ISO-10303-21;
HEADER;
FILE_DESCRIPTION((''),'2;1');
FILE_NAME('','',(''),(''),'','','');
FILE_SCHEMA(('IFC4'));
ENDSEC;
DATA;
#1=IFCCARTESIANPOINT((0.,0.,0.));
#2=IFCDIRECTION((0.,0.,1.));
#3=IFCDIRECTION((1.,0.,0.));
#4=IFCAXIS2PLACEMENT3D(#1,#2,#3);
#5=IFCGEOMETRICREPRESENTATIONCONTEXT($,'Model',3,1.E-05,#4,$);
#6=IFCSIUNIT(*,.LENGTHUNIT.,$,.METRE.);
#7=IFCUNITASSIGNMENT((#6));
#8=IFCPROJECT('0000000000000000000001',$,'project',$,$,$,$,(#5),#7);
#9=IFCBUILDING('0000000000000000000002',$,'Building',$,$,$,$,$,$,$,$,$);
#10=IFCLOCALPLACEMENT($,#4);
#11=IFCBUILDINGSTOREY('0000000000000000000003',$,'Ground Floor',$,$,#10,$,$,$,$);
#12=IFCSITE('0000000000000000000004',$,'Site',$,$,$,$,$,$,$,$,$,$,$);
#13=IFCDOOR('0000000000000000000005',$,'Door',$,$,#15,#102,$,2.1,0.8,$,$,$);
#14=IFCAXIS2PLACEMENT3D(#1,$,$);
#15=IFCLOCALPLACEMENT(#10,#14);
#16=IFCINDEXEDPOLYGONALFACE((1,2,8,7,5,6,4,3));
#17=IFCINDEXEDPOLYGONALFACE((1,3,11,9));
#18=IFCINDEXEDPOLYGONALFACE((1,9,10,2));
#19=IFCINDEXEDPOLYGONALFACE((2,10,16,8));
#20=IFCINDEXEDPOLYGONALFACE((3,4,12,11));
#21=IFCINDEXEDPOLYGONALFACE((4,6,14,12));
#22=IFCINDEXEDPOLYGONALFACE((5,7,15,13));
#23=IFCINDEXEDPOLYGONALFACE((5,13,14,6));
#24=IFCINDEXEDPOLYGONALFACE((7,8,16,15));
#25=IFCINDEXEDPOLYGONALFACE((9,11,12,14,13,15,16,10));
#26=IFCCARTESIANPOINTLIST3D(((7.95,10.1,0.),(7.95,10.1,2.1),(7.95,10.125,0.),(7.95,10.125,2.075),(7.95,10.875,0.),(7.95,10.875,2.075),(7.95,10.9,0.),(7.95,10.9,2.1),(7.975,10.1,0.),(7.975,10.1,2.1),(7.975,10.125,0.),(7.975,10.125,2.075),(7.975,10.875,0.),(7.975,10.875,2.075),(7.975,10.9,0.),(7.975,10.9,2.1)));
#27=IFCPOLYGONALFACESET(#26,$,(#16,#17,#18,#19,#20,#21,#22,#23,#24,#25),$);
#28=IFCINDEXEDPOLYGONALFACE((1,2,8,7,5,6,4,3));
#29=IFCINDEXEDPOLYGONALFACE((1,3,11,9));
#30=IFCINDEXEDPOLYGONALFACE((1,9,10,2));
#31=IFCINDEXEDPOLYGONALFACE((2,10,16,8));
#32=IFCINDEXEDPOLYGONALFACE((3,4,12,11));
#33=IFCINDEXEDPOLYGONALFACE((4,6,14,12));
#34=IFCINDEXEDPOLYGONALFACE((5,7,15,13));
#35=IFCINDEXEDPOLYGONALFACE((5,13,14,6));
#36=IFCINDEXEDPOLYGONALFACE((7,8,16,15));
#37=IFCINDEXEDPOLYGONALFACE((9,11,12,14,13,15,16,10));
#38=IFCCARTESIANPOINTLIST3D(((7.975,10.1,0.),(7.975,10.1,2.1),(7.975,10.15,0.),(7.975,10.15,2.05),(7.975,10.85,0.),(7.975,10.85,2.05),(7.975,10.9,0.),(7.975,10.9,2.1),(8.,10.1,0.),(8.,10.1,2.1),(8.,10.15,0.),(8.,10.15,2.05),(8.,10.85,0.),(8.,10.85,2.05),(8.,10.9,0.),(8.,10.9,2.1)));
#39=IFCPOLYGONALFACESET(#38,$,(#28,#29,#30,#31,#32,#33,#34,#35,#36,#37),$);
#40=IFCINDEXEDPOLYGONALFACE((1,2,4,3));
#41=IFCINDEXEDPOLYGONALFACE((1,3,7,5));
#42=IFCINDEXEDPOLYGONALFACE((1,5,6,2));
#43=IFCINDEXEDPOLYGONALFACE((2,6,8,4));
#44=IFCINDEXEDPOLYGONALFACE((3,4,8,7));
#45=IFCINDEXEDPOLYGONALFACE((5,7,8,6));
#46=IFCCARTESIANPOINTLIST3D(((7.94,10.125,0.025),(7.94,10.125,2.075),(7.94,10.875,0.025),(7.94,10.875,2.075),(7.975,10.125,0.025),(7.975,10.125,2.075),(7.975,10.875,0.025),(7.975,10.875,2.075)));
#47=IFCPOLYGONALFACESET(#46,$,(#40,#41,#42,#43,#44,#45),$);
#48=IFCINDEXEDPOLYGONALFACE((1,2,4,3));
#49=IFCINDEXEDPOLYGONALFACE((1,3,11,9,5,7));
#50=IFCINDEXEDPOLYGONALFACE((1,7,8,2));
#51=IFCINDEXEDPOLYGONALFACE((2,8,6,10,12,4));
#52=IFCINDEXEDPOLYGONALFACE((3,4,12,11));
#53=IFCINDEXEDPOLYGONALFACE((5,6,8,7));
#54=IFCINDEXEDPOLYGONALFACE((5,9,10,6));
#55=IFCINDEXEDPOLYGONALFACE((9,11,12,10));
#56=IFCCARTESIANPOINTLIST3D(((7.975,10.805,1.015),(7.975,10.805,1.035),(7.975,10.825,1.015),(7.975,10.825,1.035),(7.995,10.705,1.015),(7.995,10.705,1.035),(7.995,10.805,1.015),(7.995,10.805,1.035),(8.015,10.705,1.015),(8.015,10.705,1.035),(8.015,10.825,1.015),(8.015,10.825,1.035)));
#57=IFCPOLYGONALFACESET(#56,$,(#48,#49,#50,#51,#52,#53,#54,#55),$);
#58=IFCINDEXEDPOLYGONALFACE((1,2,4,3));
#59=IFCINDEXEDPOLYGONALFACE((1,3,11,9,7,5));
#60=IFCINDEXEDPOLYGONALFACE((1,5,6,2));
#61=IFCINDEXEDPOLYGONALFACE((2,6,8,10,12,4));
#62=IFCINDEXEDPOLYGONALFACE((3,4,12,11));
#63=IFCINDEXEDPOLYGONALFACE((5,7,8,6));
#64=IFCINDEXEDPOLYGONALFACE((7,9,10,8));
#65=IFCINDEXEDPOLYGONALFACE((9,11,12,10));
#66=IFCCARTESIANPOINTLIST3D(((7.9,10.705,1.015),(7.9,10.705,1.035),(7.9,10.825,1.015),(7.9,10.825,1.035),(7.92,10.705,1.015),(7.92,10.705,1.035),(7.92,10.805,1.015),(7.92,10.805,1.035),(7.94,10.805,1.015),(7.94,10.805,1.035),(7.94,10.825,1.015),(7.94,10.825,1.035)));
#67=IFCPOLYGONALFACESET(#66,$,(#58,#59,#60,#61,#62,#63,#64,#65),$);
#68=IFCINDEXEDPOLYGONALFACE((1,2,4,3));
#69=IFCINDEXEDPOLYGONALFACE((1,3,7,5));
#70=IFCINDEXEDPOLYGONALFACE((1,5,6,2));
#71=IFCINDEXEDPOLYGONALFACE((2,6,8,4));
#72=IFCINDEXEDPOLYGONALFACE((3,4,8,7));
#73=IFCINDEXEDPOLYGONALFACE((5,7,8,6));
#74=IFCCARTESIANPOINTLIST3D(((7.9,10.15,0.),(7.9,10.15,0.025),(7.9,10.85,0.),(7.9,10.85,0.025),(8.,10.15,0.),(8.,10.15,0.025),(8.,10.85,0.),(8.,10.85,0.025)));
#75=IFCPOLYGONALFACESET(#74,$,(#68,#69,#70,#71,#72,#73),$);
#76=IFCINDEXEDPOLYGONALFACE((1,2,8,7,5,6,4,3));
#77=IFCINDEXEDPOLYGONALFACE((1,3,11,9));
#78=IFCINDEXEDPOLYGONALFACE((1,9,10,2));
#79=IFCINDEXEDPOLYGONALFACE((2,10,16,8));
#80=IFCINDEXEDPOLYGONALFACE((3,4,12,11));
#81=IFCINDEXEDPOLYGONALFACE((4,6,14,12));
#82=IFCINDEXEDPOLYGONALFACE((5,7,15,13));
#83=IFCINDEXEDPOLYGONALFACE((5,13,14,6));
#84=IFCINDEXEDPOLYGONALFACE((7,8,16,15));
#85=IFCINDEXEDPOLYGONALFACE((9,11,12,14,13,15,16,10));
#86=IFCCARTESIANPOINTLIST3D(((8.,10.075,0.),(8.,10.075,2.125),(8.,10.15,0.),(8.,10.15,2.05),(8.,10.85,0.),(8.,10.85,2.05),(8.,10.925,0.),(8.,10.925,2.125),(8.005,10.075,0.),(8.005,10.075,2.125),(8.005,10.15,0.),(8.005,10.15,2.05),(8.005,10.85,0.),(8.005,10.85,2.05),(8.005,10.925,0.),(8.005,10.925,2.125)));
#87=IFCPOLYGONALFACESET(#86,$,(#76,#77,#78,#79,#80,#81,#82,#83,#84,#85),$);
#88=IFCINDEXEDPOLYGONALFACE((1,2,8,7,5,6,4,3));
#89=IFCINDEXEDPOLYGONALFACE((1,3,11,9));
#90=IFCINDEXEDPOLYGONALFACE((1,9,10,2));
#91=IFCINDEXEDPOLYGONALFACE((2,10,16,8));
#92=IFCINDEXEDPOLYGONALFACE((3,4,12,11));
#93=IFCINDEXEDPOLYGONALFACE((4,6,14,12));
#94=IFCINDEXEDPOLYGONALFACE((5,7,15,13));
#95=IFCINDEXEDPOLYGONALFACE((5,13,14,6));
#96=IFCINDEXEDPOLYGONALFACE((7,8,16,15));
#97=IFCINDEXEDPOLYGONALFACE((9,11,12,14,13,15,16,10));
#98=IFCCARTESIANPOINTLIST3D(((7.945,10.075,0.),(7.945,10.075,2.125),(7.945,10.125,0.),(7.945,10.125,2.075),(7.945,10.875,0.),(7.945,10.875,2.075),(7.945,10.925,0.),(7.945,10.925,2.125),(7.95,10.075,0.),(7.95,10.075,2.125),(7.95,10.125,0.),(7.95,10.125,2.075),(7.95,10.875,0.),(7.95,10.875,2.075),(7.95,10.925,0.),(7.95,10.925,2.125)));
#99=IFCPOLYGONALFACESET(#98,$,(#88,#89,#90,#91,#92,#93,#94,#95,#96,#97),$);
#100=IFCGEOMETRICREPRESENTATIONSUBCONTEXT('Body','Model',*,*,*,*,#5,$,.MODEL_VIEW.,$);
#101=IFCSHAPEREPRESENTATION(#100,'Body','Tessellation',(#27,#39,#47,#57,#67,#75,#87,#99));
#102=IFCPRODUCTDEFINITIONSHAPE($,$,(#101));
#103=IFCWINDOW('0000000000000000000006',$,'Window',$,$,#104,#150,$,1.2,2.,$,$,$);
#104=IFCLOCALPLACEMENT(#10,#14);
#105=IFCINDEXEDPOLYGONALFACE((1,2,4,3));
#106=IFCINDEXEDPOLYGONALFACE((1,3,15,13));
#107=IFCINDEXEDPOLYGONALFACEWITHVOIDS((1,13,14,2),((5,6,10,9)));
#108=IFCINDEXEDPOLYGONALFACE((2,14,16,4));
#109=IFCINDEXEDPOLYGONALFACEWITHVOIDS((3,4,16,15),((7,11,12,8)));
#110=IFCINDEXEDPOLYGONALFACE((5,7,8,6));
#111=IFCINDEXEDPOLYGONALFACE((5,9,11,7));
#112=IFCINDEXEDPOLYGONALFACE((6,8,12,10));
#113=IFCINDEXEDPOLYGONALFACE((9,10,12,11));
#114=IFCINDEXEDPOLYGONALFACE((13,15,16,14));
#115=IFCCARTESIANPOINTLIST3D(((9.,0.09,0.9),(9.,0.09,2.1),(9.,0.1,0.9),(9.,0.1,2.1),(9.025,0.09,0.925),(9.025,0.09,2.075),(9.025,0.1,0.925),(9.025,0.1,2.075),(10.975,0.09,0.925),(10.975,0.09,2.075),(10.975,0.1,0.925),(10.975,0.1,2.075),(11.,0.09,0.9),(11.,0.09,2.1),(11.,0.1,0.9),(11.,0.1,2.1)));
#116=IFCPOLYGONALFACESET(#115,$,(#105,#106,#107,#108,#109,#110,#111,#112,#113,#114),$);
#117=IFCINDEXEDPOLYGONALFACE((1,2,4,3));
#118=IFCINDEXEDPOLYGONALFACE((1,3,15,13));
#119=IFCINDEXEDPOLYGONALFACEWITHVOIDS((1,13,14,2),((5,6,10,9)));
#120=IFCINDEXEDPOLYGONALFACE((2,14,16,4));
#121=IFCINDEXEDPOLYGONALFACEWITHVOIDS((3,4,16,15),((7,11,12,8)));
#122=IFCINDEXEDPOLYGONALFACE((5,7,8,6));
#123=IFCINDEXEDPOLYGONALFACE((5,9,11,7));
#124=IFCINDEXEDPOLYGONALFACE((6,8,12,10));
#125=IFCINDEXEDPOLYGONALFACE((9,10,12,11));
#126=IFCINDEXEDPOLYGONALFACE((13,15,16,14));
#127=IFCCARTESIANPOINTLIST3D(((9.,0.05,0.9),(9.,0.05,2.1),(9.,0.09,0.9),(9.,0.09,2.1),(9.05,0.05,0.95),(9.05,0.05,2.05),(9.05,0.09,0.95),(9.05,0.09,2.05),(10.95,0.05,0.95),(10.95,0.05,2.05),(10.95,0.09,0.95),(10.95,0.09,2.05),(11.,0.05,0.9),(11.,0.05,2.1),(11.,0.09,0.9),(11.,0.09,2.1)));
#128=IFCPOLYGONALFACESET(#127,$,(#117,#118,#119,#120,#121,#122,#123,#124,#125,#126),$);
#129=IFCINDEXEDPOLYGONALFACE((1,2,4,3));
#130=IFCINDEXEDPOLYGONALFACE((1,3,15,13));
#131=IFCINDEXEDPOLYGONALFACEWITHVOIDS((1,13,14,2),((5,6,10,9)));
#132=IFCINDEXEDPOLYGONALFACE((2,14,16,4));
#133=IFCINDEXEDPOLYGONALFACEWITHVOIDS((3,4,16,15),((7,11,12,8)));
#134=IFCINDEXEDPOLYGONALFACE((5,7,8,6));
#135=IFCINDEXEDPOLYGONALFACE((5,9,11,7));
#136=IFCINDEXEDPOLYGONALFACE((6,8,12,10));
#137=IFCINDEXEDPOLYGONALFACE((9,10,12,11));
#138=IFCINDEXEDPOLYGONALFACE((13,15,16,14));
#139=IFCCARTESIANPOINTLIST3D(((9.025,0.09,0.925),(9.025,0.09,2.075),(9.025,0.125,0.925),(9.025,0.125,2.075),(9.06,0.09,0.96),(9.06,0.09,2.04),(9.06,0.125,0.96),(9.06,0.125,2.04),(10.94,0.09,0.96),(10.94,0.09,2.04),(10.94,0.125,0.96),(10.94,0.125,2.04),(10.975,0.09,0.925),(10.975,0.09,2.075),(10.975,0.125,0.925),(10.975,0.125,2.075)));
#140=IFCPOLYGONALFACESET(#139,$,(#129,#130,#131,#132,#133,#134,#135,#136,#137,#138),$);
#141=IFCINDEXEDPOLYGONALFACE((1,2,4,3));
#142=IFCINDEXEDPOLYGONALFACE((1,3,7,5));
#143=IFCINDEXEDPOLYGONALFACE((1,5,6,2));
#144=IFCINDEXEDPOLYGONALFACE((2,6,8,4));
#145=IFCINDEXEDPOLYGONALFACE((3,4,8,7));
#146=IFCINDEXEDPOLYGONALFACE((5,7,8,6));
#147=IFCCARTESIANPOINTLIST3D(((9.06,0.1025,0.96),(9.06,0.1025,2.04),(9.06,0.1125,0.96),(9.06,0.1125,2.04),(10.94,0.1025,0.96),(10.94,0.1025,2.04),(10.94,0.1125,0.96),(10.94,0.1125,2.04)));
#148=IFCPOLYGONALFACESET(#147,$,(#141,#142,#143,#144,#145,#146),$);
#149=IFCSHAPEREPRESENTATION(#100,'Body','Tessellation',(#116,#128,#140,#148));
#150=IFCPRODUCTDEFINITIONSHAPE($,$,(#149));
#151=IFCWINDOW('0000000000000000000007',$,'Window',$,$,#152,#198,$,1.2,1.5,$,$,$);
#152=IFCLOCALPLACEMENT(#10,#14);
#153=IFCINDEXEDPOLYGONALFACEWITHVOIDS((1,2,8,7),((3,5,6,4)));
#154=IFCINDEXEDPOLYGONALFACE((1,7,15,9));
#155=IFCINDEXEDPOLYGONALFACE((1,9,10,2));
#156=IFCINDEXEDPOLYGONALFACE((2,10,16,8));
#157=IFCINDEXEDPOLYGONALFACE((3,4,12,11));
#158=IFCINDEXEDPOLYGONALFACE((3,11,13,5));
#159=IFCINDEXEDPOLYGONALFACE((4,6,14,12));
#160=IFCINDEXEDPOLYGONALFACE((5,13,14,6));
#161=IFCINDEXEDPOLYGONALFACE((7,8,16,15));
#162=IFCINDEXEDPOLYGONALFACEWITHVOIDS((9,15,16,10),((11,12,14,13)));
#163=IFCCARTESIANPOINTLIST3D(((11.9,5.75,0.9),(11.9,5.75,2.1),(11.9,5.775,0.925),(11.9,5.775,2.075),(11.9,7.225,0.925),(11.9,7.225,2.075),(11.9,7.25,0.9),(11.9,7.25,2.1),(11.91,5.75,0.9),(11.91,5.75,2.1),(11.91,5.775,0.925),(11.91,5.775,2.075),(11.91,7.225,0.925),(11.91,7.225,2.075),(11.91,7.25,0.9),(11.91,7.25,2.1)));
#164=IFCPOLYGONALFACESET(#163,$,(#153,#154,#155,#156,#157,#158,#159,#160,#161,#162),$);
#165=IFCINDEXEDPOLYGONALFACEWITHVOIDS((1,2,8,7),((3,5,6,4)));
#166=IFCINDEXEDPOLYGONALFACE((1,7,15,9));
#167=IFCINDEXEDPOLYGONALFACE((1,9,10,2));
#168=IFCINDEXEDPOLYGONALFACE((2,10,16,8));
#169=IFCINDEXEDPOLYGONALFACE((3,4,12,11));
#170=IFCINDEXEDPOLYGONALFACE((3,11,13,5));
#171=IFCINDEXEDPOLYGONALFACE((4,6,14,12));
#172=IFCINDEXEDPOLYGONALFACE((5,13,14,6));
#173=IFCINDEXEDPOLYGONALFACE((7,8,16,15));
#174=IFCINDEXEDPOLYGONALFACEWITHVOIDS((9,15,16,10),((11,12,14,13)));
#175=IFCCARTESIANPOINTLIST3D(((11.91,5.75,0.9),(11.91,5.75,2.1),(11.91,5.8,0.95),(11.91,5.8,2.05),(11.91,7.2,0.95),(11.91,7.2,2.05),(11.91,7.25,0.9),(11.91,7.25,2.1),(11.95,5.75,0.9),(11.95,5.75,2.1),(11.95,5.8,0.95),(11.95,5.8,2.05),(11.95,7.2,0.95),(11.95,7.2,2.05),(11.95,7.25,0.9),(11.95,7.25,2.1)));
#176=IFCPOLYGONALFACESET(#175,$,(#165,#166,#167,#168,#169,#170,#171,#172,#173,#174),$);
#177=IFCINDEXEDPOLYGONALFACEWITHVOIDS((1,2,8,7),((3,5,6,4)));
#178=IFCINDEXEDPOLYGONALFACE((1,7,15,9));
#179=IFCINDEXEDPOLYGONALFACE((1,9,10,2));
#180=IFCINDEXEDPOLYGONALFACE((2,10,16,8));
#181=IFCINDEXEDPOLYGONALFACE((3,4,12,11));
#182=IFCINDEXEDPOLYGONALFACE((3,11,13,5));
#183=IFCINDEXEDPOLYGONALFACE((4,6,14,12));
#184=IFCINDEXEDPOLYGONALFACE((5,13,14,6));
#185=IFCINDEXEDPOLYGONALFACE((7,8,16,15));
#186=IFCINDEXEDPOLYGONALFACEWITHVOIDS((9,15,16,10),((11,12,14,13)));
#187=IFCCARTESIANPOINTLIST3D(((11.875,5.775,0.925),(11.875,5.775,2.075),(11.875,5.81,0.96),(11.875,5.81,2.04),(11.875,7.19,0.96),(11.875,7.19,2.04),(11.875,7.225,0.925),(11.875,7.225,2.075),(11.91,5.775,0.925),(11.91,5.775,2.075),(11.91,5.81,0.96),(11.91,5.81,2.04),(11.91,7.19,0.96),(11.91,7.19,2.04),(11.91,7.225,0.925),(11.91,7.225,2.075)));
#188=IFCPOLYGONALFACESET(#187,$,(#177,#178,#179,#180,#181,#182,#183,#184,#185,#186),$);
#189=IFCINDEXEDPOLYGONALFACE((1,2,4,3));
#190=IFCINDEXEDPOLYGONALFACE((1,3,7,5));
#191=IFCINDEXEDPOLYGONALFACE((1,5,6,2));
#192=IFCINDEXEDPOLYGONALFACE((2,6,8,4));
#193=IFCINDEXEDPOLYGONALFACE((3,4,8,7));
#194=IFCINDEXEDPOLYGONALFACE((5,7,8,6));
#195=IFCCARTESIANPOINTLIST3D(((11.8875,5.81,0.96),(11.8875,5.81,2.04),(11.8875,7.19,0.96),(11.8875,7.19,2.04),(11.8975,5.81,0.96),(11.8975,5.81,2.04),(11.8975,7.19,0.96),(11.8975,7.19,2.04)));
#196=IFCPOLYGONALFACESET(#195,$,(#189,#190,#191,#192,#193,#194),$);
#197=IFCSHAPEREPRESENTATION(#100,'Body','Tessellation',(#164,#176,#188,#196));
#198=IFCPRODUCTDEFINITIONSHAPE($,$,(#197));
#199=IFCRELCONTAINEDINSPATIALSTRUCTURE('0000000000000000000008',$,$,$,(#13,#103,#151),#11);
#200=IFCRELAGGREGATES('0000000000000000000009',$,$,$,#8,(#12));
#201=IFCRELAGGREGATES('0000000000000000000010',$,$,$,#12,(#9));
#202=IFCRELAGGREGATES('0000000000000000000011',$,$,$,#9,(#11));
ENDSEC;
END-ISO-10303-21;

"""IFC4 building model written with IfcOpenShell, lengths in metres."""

from ifc_helpers import new_model, si_unit, frame, origin_with_axes, place, context, subcontext, project, spatial, line, indexed_curve, outline, extrude, element, save


model = new_model("IFC4")

# Units and contexts
model_context = context("Model", 3, precision=1e-05, world=origin_with_axes())
body_context = subcontext(model_context, "Body", "Model", "MODEL_VIEW")
ifc_project = project(units=[si_unit("LENGTHUNIT", "METRE")], contexts=[model_context])

# Site, building, storey
site = spatial("IfcSite", under=ifc_project, Name="Site")
building = spatial("IfcBuilding", under=site, Name="Building")
storey_placement = place(None, origin_with_axes())
storey = spatial("IfcBuildingStorey", under=building, at=storey_placement, Name="Ground Floor")

# Door
door_1_placement = place(storey_placement, frame((8.0, 10.1, 0.0), z_axis=(0.0, 0.0, 1.0), x_axis=(0.0, 1.0, 0.0)))
element("IfcDoor", 1, at=door_1_placement, inside=storey, Name="Door", OverallHeight=2.1, OverallWidth=0.8, context=body_context, shape_type="SweptSolid", body=[
    extrude(outline(indexed_curve([(0.0, 0.0), (0.0, 2.1), (0.8, 2.1), (0.8, 0.0), (0.775, 0.0), (0.775, 2.075), (0.025, 2.075), (0.025, 0.0)], segments=[line(1, 2, 3, 4, 5, 6, 7, 8, 1)])), frame((0.0, 0.025, 0.0), z_axis=(0.0, -1.0, 0.0), x_axis=(1.0, 0.0, 0.0)), (0.0, 0.0, -1.0), 0.025),
    extrude(outline(indexed_curve([(0.0, 0.0), (0.0, 2.1), (0.8, 2.1), (0.8, 0.0), (0.75, 0.0), (0.75, 2.05), (0.05, 2.05), (0.05, 0.0)], segments=[line(1, 2, 3, 4, 5, 6, 7, 8, 1)])), frame((0.0, 0.0, 0.0), z_axis=(0.0, -1.0, 0.0), x_axis=(1.0, 0.0, 0.0)), (0.0, 0.0, -1.0), 0.025),
    extrude(outline(indexed_curve([(0.0, 0.0), (0.75, 0.0), (0.75, 0.035), (0.0, 0.035)], segments=[line(1, 2, 3, 4, 1)])), frame((0.025, 0.025, 0.025), z_axis=(0.0, 0.0, 1.0), x_axis=(1.0, 0.0, 0.0)), (0.0, 0.0, 1.0), 2.05),
    extrude(outline(indexed_curve([(0.0, 0.0), (0.0, -0.04), (-0.12, -0.04), (-0.12, -0.02), (-0.02, -0.02), (-0.02, 0.0)], segments=[line(1, 2, 3, 4, 5, 6, 1)])), frame((0.725, 0.025, 1.015), z_axis=(0.0, 0.0, 1.0), x_axis=(1.0, 0.0, 0.0)), (0.0, 0.0, 1.0), 0.02),
    extrude(outline(indexed_curve([(0.0, 0.0), (0.0, 0.04), (-0.12, 0.04), (-0.12, 0.02), (-0.02, 0.02), (-0.02, 0.0)], segments=[line(1, 2, 3, 4, 5, 6, 1)])), frame((0.725, 0.06, 1.015), z_axis=(0.0, 0.0, 1.0), x_axis=(1.0, 0.0, 0.0)), (0.0, 0.0, 1.0), 0.02),
    extrude(outline(indexed_curve([(0.0, 0.0), (0.7, 0.0), (0.7, 0.1), (0.0, 0.1)], segments=[line(1, 2, 3, 4, 1)])), frame((0.05, 0.0, 0.0), z_axis=(0.0, 0.0, 1.0), x_axis=(1.0, 0.0, 0.0)), (0.0, 0.0, 1.0), 0.025),
    extrude(outline(indexed_curve([(0.0, 0.0), (0.0, 2.125), (0.85, 2.125), (0.85, 0.0), (0.775, 0.0), (0.775, 2.05), (0.075, 2.05), (0.075, 0.0)], segments=[line(1, 2, 3, 4, 5, 6, 7, 8, 1)])), frame((-0.025, -0.005, 0.0), z_axis=(0.0, -1.0, 0.0), x_axis=(1.0, 0.0, 0.0)), (0.0, 0.0, -1.0), 0.005),
    extrude(outline(indexed_curve([(0.0, 0.0), (0.0, 2.125), (0.85, 2.125), (0.85, 0.0), (0.8, 0.0), (0.8, 2.075), (0.05, 2.075), (0.05, 0.0)], segments=[line(1, 2, 3, 4, 5, 6, 7, 8, 1)])), frame((-0.025, 0.05, 0.0), z_axis=(0.0, -1.0, 0.0), x_axis=(1.0, 0.0, 0.0)), (0.0, 0.0, -1.0), 0.005),
])

# Windows
window_1_placement = place(storey_placement, frame((9.0, 0.0, 0.9), z_axis=(0.0, 0.0, 1.0), x_axis=(1.0, 0.0, 0.0)))
element("IfcWindow", 2, at=window_1_placement, inside=storey, Name="Window", OverallHeight=1.2, OverallWidth=2.0, context=body_context, shape_type="SweptSolid", body=[
    extrude(outline(indexed_curve([(0.0, 0.0), (2.0, 0.0), (2.0, 1.2), (0.0, 1.2)], segments=[line(1, 2, 3, 4, 1)]), holes=[indexed_curve([(0.025, 0.025), (1.975, 0.025), (1.975, 1.175), (0.025, 1.175)], segments=[line(1, 2, 3, 4, 1)])]), frame((0.0, 0.09, 0.0), z_axis=(0.0, -1.0, 0.0), x_axis=(1.0, 0.0, 0.0)), (0.0, 0.0, -1.0), 0.01),
    extrude(outline(indexed_curve([(0.0, 0.0), (2.0, 0.0), (2.0, 1.2), (0.0, 1.2)], segments=[line(1, 2, 3, 4, 1)]), holes=[indexed_curve([(0.05, 0.05), (1.95, 0.05), (1.95, 1.15), (0.05, 1.15)], segments=[line(1, 2, 3, 4, 1)])]), frame((0.0, 0.05, 0.0), z_axis=(0.0, -1.0, 0.0), x_axis=(1.0, 0.0, 0.0)), (0.0, 0.0, -1.0), 0.04),
    extrude(outline(indexed_curve([(0.0, 0.0), (1.95, 0.0), (1.95, 1.15), (0.0, 1.15)], segments=[line(1, 2, 3, 4, 1)]), holes=[indexed_curve([(0.035, 0.035), (1.915, 0.035), (1.915, 1.115), (0.035, 1.115)], segments=[line(1, 2, 3, 4, 1)])]), frame((0.025, 0.09, 0.025), z_axis=(0.0, -1.0, 0.0), x_axis=(1.0, 0.0, 0.0)), (0.0, 0.0, -1.0), 0.035),
    extrude(outline(indexed_curve([(0.035, 0.035), (1.915, 0.035), (1.915, 1.115), (0.035, 1.115)], segments=[line(1, 2, 3, 4, 1)])), frame((0.025, 0.1025, 0.025), z_axis=(0.0, -1.0, 0.0), x_axis=(1.0, 0.0, 0.0)), (0.0, 0.0, -1.0), 0.01),
])
for number, where, z_axis, x_axis, name in (
    (3, (12.0, 5.75, 0.9), (0.0, 0.0, 1.0), (0.0, 1.0, 0.0), "Window"),
):
    element("IfcWindow", number, at=place(storey_placement, frame(where, z_axis=z_axis, x_axis=x_axis)), inside=storey, Name=name, OverallHeight=1.2, OverallWidth=1.5, context=body_context, shape_type="SweptSolid", body=[
        extrude(outline(indexed_curve([(0.0, 0.0), (1.5, 0.0), (1.5, 1.2), (0.0, 1.2)], segments=[line(1, 2, 3, 4, 1)]), holes=[indexed_curve([(0.025, 0.025), (1.475, 0.025), (1.475, 1.175), (0.025, 1.175)], segments=[line(1, 2, 3, 4, 1)])]), frame((0.0, 0.09, 0.0), z_axis=(0.0, -1.0, 0.0), x_axis=(1.0, 0.0, 0.0)), (0.0, 0.0, -1.0), 0.01),
        extrude(outline(indexed_curve([(0.0, 0.0), (1.5, 0.0), (1.5, 1.2), (0.0, 1.2)], segments=[line(1, 2, 3, 4, 1)]), holes=[indexed_curve([(0.05, 0.05), (1.45, 0.05), (1.45, 1.15), (0.05, 1.15)], segments=[line(1, 2, 3, 4, 1)])]), frame((0.0, 0.05, 0.0), z_axis=(0.0, -1.0, 0.0), x_axis=(1.0, 0.0, 0.0)), (0.0, 0.0, -1.0), 0.04),
        extrude(outline(indexed_curve([(0.0, 0.0), (1.45, 0.0), (1.45, 1.15), (0.0, 1.15)], segments=[line(1, 2, 3, 4, 1)]), holes=[indexed_curve([(0.035, 0.035), (1.415, 0.035), (1.415, 1.115), (0.035, 1.115)], segments=[line(1, 2, 3, 4, 1)])]), frame((0.025, 0.09, 0.025), z_axis=(0.0, -1.0, 0.0), x_axis=(1.0, 0.0, 0.0)), (0.0, 0.0, -1.0), 0.035),
        extrude(outline(indexed_curve([(0.035, 0.035), (1.415, 0.035), (1.415, 1.115), (0.035, 1.115)], segments=[line(1, 2, 3, 4, 1)])), frame((0.025, 0.1025, 0.025), z_axis=(0.0, -1.0, 0.0), x_axis=(1.0, 0.0, 0.0)), (0.0, 0.0, -1.0), 0.01),
    ])

save(model, "model.ifc")
